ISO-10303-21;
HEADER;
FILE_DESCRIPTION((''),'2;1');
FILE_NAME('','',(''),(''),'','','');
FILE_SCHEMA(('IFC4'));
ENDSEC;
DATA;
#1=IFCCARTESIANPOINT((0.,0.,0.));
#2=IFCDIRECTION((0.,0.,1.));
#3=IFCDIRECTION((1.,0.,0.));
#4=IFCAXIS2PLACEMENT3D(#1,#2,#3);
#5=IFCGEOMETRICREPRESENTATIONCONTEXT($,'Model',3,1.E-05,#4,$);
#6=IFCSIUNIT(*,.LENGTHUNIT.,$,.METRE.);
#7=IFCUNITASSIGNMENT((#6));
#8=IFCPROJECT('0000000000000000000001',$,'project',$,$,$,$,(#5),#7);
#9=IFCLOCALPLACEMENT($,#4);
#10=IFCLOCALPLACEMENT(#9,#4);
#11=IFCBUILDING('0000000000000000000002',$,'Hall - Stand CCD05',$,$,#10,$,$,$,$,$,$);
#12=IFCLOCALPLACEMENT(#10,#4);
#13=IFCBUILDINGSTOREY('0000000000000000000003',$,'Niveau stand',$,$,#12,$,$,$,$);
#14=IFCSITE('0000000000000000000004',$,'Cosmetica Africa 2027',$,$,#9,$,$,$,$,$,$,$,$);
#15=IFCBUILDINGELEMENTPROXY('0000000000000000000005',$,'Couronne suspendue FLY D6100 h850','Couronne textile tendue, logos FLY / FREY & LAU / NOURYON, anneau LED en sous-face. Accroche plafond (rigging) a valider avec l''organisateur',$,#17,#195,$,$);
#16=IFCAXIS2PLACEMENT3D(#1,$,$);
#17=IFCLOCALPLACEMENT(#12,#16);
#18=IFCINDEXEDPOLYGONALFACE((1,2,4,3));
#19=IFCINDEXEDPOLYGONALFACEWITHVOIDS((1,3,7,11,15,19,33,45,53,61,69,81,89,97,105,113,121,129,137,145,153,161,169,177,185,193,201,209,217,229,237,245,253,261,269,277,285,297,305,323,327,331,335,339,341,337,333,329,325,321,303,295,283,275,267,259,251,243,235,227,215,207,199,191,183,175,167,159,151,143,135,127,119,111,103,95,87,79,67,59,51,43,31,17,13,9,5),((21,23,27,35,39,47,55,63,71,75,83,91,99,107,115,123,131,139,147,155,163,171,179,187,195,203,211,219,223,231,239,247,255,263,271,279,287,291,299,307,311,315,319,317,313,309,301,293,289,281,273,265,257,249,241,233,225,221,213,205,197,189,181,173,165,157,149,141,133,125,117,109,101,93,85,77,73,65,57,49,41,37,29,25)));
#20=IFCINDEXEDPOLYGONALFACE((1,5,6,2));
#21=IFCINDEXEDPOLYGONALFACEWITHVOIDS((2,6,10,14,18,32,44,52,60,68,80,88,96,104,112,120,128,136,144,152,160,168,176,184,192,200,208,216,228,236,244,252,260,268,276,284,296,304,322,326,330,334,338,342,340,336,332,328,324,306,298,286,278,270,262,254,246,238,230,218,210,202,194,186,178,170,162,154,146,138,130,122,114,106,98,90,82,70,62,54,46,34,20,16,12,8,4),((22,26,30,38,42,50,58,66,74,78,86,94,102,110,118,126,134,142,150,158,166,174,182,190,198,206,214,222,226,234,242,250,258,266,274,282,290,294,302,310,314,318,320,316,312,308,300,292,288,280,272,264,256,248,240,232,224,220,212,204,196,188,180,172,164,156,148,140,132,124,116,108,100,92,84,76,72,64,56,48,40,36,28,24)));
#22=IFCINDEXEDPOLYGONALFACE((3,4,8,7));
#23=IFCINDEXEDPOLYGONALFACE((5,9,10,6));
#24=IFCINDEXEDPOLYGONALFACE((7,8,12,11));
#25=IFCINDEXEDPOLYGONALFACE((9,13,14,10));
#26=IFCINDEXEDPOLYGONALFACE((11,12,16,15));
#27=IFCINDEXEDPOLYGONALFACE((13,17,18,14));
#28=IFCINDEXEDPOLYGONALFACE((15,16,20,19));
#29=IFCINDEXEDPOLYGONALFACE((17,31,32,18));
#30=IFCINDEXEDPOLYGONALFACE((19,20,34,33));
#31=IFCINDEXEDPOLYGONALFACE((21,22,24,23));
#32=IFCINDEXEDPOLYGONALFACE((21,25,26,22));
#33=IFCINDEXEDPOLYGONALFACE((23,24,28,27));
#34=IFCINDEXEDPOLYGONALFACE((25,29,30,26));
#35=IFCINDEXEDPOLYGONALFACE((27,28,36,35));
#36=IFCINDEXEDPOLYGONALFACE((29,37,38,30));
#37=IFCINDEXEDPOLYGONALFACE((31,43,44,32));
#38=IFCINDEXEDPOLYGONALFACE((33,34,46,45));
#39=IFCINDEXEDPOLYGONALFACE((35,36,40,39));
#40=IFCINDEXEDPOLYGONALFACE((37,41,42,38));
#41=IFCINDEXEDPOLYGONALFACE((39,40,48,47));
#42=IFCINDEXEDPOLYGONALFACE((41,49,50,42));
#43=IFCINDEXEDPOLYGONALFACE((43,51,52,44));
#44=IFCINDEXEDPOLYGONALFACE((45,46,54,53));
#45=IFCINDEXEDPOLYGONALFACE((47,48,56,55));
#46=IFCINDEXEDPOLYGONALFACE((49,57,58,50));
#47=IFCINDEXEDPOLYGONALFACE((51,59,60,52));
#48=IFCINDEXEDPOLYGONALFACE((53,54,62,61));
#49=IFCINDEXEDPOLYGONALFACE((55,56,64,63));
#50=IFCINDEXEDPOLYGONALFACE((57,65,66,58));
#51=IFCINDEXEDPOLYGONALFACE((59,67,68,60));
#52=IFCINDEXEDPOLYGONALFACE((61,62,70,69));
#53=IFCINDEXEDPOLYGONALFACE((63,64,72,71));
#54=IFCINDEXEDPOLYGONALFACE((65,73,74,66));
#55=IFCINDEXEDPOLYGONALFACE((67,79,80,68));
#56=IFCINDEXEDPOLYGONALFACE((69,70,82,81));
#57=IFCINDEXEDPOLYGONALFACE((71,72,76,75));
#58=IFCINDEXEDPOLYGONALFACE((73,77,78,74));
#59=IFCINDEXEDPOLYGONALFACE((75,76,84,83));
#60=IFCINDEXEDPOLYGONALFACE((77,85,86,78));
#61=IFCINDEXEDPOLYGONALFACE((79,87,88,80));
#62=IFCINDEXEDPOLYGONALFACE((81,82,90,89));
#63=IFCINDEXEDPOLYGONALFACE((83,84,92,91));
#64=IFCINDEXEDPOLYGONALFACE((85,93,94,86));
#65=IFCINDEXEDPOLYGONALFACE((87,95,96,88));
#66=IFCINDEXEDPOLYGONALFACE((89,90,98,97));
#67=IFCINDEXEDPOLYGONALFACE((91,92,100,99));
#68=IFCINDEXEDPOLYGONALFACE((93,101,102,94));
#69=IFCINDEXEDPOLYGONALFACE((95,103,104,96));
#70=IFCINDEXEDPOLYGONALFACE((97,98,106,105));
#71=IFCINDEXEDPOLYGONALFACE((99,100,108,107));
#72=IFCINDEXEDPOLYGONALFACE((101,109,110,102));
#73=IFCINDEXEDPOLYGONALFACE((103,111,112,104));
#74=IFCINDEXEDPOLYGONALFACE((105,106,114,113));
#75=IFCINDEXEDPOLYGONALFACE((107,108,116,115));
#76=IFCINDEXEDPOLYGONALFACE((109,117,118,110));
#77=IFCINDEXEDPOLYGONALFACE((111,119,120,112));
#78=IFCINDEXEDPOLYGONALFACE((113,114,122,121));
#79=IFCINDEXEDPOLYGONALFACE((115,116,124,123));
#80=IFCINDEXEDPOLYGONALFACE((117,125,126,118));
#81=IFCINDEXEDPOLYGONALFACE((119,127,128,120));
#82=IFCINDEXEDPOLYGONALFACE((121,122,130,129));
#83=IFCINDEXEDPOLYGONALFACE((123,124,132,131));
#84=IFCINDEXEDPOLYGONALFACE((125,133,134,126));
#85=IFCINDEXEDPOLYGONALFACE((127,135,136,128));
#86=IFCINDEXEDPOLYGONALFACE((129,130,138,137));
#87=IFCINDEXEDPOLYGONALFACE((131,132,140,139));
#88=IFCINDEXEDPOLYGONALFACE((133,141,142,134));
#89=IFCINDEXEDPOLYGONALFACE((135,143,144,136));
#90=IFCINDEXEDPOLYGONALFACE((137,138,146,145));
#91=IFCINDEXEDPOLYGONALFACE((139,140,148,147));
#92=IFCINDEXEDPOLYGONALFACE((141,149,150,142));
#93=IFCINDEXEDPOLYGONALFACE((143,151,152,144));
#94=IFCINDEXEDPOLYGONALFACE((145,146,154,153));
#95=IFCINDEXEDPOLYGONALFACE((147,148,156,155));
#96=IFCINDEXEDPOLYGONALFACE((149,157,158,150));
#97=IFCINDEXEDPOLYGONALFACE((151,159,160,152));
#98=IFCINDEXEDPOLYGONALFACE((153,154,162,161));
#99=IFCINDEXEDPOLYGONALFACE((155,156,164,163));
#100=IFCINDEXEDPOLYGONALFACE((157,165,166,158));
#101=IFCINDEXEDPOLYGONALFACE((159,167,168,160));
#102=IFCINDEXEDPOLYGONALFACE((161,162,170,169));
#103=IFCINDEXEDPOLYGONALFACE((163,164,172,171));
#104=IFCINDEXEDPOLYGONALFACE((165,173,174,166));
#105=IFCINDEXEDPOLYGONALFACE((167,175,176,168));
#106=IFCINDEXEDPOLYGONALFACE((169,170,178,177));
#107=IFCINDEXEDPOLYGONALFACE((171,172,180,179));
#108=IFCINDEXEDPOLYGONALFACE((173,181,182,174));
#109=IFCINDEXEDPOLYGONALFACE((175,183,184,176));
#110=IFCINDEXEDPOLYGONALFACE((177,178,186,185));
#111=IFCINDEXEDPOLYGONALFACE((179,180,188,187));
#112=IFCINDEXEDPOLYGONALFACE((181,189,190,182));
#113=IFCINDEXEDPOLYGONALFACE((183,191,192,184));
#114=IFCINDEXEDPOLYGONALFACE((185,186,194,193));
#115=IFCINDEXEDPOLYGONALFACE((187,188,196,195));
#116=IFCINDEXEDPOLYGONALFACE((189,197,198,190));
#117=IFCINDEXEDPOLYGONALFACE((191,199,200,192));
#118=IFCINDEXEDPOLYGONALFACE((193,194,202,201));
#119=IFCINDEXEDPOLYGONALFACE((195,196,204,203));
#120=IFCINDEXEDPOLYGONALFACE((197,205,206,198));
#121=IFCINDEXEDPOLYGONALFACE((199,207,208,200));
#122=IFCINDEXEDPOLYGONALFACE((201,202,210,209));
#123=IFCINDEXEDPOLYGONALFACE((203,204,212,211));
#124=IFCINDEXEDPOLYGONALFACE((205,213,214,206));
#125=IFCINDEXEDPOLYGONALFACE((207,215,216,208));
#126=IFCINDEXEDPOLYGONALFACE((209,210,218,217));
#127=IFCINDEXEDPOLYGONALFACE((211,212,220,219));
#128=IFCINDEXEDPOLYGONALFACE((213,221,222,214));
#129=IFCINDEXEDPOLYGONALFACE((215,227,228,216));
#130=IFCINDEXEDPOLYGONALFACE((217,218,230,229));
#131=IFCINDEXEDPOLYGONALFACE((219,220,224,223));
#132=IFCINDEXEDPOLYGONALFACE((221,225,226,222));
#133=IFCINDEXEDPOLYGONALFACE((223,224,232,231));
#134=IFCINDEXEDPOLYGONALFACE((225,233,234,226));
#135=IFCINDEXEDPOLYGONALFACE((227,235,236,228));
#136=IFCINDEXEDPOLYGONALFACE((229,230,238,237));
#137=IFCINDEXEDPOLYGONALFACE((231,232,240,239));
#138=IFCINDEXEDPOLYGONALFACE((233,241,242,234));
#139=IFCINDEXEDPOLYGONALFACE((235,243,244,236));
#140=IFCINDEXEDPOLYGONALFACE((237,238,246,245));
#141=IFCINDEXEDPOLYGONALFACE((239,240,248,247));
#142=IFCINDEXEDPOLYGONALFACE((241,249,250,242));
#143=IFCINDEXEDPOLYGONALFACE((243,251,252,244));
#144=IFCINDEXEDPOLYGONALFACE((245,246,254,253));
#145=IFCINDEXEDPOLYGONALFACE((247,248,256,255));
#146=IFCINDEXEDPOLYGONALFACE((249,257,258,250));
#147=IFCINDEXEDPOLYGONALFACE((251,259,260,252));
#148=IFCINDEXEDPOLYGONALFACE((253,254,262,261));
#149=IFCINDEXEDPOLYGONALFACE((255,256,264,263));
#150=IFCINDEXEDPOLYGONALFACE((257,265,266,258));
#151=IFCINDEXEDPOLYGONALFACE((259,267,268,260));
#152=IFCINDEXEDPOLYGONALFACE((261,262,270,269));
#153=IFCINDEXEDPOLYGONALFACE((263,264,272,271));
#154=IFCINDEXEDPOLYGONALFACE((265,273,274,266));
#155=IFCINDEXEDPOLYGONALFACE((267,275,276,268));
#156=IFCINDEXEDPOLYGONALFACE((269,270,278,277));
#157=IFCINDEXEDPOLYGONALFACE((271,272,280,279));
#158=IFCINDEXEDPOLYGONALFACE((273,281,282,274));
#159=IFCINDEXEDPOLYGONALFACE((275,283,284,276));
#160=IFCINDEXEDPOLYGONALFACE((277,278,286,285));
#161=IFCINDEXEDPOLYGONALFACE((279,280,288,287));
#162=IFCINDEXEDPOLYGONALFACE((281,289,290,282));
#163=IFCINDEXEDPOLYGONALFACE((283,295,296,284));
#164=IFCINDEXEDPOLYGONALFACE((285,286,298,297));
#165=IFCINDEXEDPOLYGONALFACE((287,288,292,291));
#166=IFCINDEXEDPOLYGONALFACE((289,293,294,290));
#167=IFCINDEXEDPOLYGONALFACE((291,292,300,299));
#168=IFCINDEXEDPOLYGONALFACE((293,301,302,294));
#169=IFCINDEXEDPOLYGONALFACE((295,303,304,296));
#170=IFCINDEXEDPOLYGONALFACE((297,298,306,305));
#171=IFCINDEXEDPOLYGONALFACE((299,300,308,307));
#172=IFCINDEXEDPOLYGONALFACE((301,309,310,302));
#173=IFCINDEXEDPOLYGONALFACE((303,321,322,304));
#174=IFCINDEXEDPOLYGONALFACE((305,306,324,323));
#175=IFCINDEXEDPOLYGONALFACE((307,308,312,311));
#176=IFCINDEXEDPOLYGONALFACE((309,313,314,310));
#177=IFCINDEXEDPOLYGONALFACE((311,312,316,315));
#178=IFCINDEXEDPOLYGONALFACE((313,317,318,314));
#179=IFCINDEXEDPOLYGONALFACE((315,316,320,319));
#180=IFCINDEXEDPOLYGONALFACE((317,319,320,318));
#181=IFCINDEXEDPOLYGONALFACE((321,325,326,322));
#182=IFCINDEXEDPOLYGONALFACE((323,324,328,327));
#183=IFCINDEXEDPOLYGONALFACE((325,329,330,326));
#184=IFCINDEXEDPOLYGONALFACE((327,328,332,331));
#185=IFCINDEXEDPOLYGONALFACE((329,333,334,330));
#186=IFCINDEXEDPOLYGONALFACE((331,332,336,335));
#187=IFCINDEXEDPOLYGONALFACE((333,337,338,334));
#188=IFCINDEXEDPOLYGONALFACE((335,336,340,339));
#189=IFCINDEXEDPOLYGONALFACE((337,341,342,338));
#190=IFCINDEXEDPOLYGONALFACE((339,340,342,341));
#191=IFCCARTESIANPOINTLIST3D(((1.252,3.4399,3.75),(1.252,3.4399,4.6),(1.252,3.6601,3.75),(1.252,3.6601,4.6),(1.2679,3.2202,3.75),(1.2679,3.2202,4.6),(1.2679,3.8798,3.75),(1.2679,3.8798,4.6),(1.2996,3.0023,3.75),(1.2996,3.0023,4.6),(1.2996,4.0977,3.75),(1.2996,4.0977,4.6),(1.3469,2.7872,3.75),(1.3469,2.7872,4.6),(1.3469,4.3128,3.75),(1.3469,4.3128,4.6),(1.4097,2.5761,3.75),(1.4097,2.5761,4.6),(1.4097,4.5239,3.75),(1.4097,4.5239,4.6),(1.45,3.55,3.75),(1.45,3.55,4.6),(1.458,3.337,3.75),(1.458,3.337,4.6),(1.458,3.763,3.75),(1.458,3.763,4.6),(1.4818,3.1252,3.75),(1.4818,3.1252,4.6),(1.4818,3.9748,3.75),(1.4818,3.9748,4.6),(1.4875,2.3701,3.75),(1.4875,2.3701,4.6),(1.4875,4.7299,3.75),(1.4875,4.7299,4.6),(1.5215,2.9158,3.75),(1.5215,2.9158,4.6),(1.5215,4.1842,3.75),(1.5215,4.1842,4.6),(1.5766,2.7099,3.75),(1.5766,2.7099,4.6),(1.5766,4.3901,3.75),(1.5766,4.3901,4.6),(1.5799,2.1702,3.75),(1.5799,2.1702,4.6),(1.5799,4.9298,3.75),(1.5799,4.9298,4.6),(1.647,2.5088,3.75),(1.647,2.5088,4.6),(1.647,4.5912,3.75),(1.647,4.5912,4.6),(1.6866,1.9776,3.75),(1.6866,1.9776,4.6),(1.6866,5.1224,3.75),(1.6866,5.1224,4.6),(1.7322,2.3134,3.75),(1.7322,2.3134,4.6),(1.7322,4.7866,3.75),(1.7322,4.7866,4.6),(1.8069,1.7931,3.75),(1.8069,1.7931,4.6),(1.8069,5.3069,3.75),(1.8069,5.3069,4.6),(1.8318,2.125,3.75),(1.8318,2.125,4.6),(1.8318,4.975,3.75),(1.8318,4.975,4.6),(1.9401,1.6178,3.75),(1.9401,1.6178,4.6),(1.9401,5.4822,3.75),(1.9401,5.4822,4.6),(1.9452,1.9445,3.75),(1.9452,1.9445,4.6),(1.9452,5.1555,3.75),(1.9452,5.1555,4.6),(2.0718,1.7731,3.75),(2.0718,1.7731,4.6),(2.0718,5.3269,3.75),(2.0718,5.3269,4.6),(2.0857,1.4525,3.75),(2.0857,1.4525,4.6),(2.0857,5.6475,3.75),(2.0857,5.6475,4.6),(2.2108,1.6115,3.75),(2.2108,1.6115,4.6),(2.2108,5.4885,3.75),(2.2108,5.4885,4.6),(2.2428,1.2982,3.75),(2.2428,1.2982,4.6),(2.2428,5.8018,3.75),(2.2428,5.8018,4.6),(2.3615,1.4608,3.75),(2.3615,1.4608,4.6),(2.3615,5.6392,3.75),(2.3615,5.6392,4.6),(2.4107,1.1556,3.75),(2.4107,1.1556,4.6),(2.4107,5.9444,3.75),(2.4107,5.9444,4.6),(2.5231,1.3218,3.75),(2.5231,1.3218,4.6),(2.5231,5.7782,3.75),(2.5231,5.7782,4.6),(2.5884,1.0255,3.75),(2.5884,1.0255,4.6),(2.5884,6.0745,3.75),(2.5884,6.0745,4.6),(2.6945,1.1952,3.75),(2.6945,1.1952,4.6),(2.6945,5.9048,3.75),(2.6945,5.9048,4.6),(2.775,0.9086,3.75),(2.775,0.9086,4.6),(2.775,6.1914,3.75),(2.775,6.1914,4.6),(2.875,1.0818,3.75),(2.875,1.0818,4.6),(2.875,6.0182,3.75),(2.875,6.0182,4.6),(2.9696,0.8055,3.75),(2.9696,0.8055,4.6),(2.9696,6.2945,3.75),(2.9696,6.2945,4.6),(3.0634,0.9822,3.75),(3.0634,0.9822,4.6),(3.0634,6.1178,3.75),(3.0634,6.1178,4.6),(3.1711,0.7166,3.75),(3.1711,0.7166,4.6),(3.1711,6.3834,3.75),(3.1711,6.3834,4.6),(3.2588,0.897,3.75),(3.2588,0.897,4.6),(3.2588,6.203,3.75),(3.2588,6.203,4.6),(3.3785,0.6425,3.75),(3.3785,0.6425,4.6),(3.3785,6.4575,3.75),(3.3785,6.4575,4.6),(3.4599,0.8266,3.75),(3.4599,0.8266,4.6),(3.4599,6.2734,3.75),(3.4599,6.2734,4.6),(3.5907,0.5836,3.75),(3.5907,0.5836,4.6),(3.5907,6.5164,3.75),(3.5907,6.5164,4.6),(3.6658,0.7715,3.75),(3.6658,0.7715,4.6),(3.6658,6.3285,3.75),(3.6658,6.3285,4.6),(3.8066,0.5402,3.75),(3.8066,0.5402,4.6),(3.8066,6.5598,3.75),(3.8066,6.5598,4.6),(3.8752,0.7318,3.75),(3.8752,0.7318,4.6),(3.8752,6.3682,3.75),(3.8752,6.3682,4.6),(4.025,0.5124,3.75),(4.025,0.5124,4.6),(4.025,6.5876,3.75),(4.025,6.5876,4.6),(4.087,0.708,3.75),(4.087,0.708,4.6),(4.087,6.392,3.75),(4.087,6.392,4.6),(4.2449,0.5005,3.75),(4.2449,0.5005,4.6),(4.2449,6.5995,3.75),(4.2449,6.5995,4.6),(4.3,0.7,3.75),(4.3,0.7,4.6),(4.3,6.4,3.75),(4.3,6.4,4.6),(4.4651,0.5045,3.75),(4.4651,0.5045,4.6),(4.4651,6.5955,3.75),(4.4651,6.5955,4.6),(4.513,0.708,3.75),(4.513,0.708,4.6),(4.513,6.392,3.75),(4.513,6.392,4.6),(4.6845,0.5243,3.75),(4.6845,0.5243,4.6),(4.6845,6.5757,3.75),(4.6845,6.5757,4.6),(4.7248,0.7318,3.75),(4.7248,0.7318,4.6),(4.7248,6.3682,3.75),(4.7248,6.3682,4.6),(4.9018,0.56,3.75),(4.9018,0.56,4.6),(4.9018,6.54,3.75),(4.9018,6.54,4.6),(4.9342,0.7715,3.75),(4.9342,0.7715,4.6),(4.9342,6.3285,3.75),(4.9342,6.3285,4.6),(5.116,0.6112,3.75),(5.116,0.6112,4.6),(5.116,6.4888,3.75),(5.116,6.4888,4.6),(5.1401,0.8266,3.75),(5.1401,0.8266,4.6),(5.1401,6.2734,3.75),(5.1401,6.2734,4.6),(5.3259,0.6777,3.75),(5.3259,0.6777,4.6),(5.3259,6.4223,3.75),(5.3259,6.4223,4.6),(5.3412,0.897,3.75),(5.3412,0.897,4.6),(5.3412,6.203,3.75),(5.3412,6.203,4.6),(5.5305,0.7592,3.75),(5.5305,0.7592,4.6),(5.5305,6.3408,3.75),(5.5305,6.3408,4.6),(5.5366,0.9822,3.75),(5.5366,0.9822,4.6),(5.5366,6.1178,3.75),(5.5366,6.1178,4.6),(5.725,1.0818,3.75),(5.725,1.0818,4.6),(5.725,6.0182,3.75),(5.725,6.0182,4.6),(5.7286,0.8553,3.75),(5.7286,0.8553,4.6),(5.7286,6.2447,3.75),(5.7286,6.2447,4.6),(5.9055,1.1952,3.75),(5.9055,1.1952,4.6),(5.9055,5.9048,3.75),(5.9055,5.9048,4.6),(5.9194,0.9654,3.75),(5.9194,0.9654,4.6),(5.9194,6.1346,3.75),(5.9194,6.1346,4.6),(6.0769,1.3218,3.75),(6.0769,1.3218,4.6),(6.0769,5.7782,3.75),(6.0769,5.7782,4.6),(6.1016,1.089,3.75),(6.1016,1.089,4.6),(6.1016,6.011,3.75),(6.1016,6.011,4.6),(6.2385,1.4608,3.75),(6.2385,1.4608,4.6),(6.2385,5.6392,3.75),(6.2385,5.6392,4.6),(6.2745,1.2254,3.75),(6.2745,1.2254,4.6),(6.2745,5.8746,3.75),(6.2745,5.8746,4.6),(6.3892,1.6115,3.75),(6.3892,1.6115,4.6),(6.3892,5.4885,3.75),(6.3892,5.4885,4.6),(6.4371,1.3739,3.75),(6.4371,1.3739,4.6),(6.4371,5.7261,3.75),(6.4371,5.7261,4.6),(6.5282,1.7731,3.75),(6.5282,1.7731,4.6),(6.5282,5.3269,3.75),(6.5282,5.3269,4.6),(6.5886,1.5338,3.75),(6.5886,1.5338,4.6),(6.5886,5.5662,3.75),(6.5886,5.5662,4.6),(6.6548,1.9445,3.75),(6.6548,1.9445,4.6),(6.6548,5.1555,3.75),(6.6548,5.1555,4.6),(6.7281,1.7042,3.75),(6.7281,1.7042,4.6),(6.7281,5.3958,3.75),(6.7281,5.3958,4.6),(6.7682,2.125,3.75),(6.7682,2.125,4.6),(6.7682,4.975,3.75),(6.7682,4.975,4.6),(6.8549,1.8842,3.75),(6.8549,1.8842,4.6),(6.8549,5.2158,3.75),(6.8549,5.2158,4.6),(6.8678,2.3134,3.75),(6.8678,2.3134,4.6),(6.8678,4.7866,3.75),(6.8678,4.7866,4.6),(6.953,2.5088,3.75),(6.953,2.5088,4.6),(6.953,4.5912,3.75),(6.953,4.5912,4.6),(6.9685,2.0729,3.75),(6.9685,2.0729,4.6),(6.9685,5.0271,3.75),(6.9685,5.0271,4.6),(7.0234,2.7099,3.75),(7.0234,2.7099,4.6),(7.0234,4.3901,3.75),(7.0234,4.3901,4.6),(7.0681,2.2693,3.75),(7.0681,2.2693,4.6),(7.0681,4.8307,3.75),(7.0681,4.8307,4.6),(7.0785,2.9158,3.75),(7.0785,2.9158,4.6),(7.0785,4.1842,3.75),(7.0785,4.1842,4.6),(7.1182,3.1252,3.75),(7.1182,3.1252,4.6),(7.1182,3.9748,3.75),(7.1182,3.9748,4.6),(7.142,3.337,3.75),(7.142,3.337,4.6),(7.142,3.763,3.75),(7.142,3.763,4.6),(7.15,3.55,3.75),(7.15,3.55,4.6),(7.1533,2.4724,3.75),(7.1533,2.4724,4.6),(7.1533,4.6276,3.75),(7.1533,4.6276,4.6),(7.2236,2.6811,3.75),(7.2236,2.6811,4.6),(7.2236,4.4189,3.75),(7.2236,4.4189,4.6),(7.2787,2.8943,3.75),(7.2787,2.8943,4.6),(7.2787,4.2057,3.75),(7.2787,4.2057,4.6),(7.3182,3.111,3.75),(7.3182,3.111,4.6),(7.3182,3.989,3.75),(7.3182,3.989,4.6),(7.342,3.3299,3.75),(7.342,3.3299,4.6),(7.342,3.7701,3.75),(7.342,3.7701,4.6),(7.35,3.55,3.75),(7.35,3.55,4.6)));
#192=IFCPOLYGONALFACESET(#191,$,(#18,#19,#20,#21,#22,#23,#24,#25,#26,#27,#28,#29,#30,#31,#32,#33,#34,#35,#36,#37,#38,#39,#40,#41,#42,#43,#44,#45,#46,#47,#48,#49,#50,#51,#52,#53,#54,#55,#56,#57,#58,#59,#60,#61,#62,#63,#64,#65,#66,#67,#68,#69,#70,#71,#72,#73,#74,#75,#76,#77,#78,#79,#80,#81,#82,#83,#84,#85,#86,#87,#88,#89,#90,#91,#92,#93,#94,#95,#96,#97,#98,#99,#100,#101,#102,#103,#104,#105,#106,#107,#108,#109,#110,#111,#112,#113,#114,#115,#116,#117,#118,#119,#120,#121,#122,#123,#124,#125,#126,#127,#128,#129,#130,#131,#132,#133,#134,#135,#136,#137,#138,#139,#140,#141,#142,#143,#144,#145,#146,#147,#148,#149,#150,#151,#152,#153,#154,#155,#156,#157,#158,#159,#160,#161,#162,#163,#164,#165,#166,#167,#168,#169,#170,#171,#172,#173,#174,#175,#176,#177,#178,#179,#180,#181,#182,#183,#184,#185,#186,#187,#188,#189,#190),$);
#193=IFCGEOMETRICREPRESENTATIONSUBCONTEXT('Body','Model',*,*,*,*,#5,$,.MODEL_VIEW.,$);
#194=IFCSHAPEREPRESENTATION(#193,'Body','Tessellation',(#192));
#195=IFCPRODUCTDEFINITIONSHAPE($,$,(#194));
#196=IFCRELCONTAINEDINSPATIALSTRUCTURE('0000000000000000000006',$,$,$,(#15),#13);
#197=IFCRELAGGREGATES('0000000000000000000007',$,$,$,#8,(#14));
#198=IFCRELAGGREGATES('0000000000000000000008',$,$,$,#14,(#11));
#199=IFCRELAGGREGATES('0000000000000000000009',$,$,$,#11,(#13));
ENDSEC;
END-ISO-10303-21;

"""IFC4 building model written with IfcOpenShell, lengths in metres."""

from ifc_helpers import new_model, si_unit, frame, frame_2d, origin_with_axes, place, context, subcontext, project, spatial, hollow_circle, extrude, element, save


model = new_model("IFC4")

# Units and contexts
model_context = context("Model", 3, precision=1e-05, world=origin_with_axes())
body_context = subcontext(model_context, "Body", "Model", "MODEL_VIEW")
ifc_project = project(units=[si_unit("LENGTHUNIT", "METRE")], contexts=[model_context])

# Site, building, storey
site_placement = place(None, origin_with_axes())
site = spatial("IfcSite", under=ifc_project, at=site_placement, Name="Cosmetica Africa 2027")
building_placement = place(site_placement, origin_with_axes())
building = spatial("IfcBuilding", under=site, at=building_placement, Name="Hall - Stand CCD05")
storey_placement = place(building_placement, origin_with_axes())
storey = spatial("IfcBuildingStorey", under=building, at=storey_placement, Name="Niveau stand")

# Building element proxy
proxy_1_placement = place(storey_placement, origin_with_axes())
element("IfcBuildingElementProxy", 1, at=proxy_1_placement, inside=storey, Name="Couronne suspendue FLY D6100 h850", Description="Couronne textile tendue, logos FLY / FREY & LAU / NOURYON, anneau LED en sous-face. Accroche plafond (rigging) a valider avec l'organisateur", context=body_context, shape_type="SweptSolid", body=[
    extrude(hollow_circle(Radius=3.05, WallThickness=0.2, at=frame_2d((4.3, 3.55))), frame((0.0, 0.0, 3.75)), (0.0, 0.0, 1.0), 0.85),
])

save(model, "model.ifc")
